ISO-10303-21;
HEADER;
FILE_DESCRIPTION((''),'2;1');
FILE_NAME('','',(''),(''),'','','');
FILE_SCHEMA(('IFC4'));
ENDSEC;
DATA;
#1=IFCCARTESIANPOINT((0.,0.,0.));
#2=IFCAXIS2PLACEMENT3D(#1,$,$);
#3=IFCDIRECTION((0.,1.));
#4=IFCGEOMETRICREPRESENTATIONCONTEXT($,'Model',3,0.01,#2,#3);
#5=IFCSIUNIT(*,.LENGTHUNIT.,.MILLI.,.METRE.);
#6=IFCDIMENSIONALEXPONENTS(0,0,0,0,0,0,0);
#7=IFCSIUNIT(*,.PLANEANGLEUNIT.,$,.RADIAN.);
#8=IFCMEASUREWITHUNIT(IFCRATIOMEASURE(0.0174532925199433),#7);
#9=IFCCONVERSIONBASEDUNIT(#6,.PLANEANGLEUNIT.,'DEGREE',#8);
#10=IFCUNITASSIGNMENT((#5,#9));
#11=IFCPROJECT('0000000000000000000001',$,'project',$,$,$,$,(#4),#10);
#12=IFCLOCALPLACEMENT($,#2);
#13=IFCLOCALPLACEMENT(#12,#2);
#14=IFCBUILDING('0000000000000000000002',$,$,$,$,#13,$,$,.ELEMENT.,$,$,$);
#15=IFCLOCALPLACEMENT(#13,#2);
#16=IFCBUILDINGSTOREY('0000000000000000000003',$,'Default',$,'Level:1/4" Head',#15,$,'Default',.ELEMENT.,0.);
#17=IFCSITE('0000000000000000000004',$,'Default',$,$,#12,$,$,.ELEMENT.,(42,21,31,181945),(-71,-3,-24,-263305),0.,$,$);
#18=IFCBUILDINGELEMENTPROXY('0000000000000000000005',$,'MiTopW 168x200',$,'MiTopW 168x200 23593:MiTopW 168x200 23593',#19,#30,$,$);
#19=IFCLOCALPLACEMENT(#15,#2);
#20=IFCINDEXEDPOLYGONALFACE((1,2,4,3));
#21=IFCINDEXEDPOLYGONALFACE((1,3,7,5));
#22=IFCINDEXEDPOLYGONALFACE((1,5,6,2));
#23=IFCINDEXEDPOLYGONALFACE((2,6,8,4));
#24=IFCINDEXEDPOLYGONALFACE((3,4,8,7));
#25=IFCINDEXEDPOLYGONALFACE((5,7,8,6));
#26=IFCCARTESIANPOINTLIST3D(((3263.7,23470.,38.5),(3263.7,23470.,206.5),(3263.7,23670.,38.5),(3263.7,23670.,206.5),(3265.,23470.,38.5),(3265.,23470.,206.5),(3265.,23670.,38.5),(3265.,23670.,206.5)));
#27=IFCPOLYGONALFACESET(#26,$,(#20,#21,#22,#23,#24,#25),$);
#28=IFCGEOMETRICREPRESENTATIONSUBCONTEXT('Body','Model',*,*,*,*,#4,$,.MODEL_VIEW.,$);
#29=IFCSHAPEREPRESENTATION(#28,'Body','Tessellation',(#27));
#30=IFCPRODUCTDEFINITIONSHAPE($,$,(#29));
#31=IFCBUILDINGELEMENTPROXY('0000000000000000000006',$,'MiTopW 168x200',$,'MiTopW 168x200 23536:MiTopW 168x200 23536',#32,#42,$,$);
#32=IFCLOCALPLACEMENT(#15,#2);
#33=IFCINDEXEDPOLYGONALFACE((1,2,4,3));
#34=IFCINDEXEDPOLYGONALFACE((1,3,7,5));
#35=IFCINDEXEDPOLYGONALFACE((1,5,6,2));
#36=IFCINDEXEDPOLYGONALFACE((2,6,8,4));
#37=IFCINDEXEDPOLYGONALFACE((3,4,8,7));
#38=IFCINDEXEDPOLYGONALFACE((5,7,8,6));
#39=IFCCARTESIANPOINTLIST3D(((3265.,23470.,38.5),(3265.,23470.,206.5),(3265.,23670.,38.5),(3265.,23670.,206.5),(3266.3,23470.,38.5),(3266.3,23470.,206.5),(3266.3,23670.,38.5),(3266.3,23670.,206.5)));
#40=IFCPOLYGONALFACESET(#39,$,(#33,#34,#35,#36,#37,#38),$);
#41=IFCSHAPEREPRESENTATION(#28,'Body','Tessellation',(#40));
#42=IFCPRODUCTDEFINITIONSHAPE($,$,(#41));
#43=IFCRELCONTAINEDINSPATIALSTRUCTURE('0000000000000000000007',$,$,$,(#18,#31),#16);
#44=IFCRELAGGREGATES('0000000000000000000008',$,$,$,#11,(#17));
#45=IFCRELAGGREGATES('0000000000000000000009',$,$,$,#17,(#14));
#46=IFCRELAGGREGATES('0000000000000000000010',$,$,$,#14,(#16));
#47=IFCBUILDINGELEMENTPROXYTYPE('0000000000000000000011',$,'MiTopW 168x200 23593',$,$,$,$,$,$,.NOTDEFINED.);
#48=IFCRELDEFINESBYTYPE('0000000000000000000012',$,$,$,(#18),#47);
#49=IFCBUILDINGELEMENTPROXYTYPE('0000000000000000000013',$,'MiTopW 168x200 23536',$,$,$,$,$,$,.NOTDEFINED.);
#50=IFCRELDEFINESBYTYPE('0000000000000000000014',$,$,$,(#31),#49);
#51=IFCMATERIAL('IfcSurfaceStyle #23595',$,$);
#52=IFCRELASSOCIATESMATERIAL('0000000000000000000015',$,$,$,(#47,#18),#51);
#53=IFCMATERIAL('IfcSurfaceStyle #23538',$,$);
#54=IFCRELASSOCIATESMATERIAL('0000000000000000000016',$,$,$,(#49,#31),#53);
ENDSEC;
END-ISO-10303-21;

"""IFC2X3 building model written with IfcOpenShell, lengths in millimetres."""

from ifc_helpers import new_model, entity, si_unit, converted_unit, direction, frame, origin, origin_2d_with_axis, place, context, subcontext, project, spatial, rectangle, extrude, source, transform, mapped, material, type_object, type_shapes, element, save


model = new_model("IFC2X3")

# Units and contexts
model_context = context("Model", 3, precision=0.01, world=origin(), true_north=direction((0.0, 1.0)))
body_context = subcontext(model_context, "Body", "Model", "MODEL_VIEW")
ifc_project = project(units=[si_unit("LENGTHUNIT", "METRE", prefix="MILLI"), converted_unit("PLANEANGLEUNIT", "DEGREE", entity("IfcRatioMeasure", 0.0174532925199433), si_unit("PLANEANGLEUNIT", "RADIAN"), dimensions=[0, 0, 0, 0, 0, 0, 0])], contexts=[model_context])

# Site, building, storey
site_placement = place(None, origin())
site = spatial("IfcSite", under=ifc_project, at=site_placement, Name="Default", CompositionType="ELEMENT", RefLatitude=(42, 21, 31, 181945), RefLongitude=(-71, -3, -24, -263305), RefElevation=0.0)
building_placement = place(site_placement, origin())
building = spatial("IfcBuilding", under=site, at=building_placement, CompositionType="ELEMENT")
storey_placement = place(building_placement, origin())
storey = spatial("IfcBuildingStorey", under=building, at=storey_placement, Name="Default", ObjectType="Level:1/4\" Head", LongName="Default", CompositionType="ELEMENT", Elevation=0.0)

# Building element proxies
ifc_material_1 = material(Name="IfcSurfaceStyle #23595")
building_element_proxy_type_1 = type_object("IfcBuildingElementProxyType", Name="MiTopW 168x200 23593", PredefinedType="NOTDEFINED", material=ifc_material_1)
shared_shape_1 = source(origin(), body_context, "Body", "SweptSolid", [
    extrude(rectangle(XDim=200.0, YDim=168.0, at=origin_2d_with_axis()), frame((100.0, 84.0, 0.0), z_axis=(0.0, 0.0, 1.0), x_axis=(-1.0, 0.0, 0.0)), (0.0, 0.0, 1.0), 1.3),
])
type_shapes(building_element_proxy_type_1, [shared_shape_1])
proxy_1_placement = place(building_placement, frame((3265.0, 23470.0, 206.5), z_axis=(-1.0, 0.0, 0.0), x_axis=(0.0, 1.0, 0.0)))
element("IfcBuildingElementProxy", 1, at=proxy_1_placement, inside=storey, type_object=building_element_proxy_type_1, material=ifc_material_1, Name="MiTopW 168x200", ObjectType="MiTopW 168x200 23593:MiTopW 168x200 23593", context=body_context, shape_type="MappedRepresentation", body=[
    mapped(shared_shape_1, transform((0.0, 0.0, 0.0), scale=1.0)),
])
ifc_material_2 = material(Name="IfcSurfaceStyle #23538")
building_element_proxy_type_2 = type_object("IfcBuildingElementProxyType", Name="MiTopW 168x200 23536", PredefinedType="NOTDEFINED", material=ifc_material_2)
shared_shape_2 = source(origin(), body_context, "Body", "SweptSolid", [
    extrude(rectangle(XDim=200.0, YDim=168.0, at=origin_2d_with_axis()), frame((100.0, 84.0, 0.0), z_axis=(0.0, 0.0, 1.0), x_axis=(-1.0, 0.0, 0.0)), (0.0, 0.0, 1.0), 1.3),
])
type_shapes(building_element_proxy_type_2, [shared_shape_2])
proxy_2_placement = place(building_placement, frame((3266.3, 23470.0, 206.5), z_axis=(-1.0, 0.0, 0.0), x_axis=(0.0, 1.0, 0.0)))
element("IfcBuildingElementProxy", 2, at=proxy_2_placement, inside=storey, type_object=building_element_proxy_type_2, material=ifc_material_2, Name="MiTopW 168x200", ObjectType="MiTopW 168x200 23536:MiTopW 168x200 23536", context=body_context, shape_type="MappedRepresentation", body=[
    mapped(shared_shape_2, transform((0.0, 0.0, 0.0), scale=1.0)),
])

save(model, "model.ifc")
